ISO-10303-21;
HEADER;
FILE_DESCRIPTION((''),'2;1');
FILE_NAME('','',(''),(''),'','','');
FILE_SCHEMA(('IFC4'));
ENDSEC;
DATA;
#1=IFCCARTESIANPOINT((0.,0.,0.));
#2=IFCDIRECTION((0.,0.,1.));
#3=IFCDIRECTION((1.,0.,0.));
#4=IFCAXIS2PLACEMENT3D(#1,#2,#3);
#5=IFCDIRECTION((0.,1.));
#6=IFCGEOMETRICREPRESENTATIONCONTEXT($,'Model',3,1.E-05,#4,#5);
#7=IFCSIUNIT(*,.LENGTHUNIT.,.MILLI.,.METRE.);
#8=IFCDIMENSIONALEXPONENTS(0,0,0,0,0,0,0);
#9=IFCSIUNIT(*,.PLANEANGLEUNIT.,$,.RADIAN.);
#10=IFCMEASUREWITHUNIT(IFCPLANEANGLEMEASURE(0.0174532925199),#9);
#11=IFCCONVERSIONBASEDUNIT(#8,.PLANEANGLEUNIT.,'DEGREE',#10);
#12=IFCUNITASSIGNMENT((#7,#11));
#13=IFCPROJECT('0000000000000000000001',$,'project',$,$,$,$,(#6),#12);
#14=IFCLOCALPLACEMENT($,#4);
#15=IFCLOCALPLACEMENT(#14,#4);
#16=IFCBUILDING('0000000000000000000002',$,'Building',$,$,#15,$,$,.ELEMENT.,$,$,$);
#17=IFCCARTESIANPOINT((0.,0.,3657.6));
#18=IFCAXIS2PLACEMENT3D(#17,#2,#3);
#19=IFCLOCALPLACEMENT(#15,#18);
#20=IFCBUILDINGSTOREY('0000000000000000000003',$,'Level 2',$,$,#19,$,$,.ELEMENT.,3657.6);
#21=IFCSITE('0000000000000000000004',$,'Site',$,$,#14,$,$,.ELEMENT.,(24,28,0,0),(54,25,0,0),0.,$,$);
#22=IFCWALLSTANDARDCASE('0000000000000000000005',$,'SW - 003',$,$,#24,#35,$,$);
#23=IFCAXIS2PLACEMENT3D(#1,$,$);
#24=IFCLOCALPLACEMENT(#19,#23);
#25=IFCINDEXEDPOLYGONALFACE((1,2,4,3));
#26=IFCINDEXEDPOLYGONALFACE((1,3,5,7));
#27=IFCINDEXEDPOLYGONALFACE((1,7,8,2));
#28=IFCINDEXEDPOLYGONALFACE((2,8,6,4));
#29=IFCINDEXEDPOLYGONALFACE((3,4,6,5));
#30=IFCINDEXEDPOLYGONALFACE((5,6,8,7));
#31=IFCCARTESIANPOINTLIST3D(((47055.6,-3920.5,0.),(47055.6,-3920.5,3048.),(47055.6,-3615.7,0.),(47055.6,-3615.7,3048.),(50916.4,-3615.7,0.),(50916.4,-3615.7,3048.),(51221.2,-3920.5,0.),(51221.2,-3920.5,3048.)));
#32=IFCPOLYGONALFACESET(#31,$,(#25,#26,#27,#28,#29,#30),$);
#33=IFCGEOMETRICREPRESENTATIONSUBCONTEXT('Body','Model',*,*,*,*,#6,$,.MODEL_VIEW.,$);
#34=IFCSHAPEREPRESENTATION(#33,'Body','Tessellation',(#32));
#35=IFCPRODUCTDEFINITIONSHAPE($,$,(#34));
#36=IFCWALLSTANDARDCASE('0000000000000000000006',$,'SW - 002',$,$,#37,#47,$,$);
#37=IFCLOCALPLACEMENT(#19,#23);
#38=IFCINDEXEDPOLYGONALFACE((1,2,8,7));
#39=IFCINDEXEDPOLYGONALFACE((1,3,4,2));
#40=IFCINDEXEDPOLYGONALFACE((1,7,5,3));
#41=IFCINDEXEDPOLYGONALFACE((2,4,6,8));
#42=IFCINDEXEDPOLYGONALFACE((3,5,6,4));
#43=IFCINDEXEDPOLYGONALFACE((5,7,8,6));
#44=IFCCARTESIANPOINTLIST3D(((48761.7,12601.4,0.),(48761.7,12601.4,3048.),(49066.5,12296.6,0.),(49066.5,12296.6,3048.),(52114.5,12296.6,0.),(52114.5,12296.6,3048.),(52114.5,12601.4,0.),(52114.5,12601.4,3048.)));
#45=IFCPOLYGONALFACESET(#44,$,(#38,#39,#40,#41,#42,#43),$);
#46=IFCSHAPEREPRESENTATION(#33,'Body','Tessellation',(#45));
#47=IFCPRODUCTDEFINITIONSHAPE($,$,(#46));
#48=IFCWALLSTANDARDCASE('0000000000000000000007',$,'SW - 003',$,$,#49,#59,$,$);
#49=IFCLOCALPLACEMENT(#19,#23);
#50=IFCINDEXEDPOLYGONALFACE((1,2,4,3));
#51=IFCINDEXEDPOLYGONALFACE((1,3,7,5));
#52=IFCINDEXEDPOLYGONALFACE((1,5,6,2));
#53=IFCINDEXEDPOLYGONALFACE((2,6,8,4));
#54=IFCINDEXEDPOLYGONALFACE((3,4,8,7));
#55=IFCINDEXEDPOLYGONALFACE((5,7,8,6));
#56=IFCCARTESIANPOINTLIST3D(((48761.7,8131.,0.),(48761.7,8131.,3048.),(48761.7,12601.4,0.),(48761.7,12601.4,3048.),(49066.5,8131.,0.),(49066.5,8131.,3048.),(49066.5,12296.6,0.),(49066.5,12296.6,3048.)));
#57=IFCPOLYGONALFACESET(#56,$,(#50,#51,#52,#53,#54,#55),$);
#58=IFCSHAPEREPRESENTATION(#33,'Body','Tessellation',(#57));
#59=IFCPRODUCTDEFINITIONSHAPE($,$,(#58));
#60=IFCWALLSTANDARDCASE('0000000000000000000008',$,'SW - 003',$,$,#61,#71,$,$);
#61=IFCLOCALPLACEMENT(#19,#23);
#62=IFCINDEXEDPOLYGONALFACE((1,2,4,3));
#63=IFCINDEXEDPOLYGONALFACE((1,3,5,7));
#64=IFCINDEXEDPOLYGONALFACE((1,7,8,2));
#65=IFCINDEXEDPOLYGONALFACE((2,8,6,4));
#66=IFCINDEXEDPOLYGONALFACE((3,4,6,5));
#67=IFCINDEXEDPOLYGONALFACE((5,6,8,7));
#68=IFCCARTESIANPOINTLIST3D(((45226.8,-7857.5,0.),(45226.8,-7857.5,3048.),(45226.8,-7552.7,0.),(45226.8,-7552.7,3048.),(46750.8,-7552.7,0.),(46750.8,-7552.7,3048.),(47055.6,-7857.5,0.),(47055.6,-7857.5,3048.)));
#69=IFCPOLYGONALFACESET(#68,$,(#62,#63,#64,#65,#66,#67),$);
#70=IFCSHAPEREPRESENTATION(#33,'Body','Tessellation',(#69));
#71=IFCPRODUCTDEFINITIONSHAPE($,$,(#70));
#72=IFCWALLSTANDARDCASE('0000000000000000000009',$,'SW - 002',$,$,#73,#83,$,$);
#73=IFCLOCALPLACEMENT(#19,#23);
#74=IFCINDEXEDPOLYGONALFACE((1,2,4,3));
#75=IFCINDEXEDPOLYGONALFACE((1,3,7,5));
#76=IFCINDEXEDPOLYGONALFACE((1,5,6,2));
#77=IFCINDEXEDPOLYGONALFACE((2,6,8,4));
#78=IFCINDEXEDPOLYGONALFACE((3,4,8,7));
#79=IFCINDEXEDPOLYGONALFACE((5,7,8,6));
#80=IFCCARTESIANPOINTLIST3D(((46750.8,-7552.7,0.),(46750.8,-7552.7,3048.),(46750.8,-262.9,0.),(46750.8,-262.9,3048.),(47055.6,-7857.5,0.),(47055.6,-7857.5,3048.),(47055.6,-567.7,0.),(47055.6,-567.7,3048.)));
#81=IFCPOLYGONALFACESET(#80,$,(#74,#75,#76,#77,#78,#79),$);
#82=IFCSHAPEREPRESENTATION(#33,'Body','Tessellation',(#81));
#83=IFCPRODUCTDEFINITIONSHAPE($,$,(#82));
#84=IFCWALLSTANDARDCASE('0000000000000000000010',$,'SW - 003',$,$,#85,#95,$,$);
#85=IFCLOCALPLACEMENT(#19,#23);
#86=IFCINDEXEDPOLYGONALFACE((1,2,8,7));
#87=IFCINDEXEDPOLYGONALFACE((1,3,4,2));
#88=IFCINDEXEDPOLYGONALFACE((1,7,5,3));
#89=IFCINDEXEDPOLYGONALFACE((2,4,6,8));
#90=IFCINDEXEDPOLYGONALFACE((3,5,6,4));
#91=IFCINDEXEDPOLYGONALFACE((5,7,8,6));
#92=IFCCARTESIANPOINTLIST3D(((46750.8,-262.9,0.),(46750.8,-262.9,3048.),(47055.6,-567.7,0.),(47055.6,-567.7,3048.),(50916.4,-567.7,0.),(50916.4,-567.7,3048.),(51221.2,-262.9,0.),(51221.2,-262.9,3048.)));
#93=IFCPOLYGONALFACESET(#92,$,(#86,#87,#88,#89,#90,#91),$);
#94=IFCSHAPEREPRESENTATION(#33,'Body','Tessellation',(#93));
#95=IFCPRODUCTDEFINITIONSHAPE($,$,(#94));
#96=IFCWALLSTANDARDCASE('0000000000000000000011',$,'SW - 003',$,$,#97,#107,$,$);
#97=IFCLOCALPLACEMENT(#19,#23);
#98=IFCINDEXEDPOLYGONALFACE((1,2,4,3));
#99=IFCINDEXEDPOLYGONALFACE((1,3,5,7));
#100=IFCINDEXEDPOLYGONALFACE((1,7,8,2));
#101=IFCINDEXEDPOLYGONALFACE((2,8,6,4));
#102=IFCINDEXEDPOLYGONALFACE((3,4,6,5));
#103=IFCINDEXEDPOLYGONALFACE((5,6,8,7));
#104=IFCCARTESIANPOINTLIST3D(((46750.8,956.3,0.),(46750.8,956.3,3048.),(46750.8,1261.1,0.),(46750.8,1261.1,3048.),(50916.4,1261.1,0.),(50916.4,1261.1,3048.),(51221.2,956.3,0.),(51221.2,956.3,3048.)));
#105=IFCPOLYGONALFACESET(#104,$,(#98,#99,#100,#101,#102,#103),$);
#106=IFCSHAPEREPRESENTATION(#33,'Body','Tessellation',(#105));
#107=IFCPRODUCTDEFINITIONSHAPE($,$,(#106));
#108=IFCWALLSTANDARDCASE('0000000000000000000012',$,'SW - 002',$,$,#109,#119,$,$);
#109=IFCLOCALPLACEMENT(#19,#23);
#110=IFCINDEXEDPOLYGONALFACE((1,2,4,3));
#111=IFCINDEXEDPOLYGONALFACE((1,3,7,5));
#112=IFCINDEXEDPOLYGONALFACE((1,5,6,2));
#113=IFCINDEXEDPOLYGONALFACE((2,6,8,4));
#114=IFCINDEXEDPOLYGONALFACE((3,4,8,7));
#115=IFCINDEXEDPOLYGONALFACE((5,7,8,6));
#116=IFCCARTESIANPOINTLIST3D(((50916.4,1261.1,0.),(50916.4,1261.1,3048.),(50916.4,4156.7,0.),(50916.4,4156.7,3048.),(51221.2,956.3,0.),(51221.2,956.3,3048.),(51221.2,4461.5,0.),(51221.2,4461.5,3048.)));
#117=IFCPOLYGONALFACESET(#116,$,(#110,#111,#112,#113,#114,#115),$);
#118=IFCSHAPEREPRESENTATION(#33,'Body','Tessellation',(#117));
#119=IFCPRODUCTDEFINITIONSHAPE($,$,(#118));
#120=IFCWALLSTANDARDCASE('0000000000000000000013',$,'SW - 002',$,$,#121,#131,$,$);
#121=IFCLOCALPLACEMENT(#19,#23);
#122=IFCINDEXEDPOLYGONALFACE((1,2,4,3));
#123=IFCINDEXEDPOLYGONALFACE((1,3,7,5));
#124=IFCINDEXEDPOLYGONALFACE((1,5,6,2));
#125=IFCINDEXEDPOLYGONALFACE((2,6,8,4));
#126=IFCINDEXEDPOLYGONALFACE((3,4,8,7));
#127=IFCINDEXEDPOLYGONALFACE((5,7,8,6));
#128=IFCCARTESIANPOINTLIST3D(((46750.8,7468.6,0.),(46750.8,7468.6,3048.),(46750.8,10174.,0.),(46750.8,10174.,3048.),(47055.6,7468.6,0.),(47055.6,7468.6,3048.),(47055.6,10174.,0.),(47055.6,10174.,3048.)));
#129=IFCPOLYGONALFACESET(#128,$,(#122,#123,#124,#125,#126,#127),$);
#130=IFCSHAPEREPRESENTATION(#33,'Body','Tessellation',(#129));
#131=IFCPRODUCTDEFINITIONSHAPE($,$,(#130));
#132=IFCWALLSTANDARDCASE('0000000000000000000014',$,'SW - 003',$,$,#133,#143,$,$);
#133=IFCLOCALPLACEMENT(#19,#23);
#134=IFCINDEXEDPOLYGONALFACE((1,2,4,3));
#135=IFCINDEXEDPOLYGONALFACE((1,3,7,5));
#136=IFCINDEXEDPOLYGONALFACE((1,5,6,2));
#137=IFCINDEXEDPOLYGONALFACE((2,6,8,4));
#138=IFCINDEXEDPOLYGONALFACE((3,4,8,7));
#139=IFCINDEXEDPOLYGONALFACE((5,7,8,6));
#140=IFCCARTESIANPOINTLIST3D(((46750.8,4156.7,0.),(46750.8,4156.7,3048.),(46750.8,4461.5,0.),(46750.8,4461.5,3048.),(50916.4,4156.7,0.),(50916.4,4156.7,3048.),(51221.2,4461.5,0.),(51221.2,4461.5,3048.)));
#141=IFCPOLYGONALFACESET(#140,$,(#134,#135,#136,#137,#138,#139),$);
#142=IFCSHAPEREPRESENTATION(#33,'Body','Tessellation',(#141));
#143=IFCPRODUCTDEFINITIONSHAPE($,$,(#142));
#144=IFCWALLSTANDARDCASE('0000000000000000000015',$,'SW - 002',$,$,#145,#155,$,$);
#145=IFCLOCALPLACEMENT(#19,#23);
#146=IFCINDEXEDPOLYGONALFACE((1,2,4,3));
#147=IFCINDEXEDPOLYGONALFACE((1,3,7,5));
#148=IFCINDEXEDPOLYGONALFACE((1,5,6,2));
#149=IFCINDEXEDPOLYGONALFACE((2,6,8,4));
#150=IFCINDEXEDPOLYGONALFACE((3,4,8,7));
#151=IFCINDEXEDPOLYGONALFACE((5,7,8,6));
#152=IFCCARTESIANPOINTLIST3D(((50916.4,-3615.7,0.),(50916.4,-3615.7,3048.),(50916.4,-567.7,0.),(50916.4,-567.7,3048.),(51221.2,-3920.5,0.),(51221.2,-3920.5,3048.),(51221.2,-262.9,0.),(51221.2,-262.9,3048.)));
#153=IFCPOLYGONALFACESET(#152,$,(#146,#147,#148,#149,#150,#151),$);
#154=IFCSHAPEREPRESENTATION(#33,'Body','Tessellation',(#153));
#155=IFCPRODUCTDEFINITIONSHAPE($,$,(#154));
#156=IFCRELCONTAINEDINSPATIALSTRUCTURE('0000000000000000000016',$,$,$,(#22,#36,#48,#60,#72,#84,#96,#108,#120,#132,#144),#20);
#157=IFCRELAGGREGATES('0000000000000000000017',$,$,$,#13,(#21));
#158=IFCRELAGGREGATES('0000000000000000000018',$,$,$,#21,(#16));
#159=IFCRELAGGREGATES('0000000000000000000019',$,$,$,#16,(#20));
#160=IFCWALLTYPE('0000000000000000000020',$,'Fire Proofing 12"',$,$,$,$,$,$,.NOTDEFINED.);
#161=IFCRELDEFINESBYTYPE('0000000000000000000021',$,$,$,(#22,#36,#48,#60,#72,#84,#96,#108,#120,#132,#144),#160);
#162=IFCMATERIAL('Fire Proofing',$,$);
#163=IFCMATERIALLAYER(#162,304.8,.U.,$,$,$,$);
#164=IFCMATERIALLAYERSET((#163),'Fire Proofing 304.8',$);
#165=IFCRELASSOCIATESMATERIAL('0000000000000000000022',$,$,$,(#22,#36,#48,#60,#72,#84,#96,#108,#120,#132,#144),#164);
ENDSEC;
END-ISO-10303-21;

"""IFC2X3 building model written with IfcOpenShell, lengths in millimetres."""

from ifc_helpers import new_model, entity, si_unit, converted_unit, direction, frame, origin_with_axes, place, context, subcontext, project, spatial, polyline, outline, extrude, material, layer, layer_set, layer_usage, type_object, element, save


model = new_model("IFC2X3")

# Units and contexts
model_context = context("Model", 3, precision=1e-05, world=origin_with_axes(), true_north=direction((0.0, 1.0)))
body_context = subcontext(model_context, "Body", "Model", "MODEL_VIEW")
ifc_project = project(units=[si_unit("LENGTHUNIT", "METRE", prefix="MILLI"), converted_unit("PLANEANGLEUNIT", "DEGREE", entity("IfcPlaneAngleMeasure", 0.0174532925199), si_unit("PLANEANGLEUNIT", "RADIAN"), dimensions=[0, 0, 0, 0, 0, 0, 0])], contexts=[model_context])

# Site, building, storey
site_placement = place(None, origin_with_axes())
site = spatial("IfcSite", under=ifc_project, at=site_placement, Name="Site", CompositionType="ELEMENT", RefLatitude=(24, 28, 0, 0), RefLongitude=(54, 25, 0, 0), RefElevation=0.0)
building_placement = place(site_placement, origin_with_axes())
building = spatial("IfcBuilding", under=site, at=building_placement, Name="Building", CompositionType="ELEMENT")
storey_placement = place(building_placement, frame((0.0, 0.0, 3657.6), z_axis=(0.0, 0.0, 1.0), x_axis=(1.0, 0.0, 0.0)))
storey = spatial("IfcBuildingStorey", under=building, at=storey_placement, Name="Level 2", CompositionType="ELEMENT", Elevation=3657.6)

# Walls
ifc_material_1 = material(Name="Fire Proofing")
ifc_layer = layer(ifc_material_1, 304.8, ventilated="UNKNOWN")
ifc_layer_set = layer_set([ifc_layer], Name="Fire Proofing 304.8")
ifc_layer_usage_1 = layer_usage(ifc_layer_set, "AXIS2", "NEGATIVE", 152.4)
wall_type = type_object("IfcWallType", Name="Fire Proofing 12\"", PredefinedType="NOTDEFINED")
wall_1_placement = place(storey_placement, frame((51068.8, -3768.1, 0.0), z_axis=(0.0, 0.0, 1.0), x_axis=(-1.0, 0.0, 0.0)))
element("IfcWallStandardCase", 1, at=wall_1_placement, inside=storey, type_object=wall_type, material=ifc_layer_usage_1, Name="SW - 003", context=body_context, shape_type="SweptSolid", body=[
    extrude(outline(polyline([(152.4, -152.4), (4013.2, -152.4), (4013.2, 152.4), (-152.4, 152.4), (152.4, -152.4)])), origin_with_axes(), (0.0, 0.0, 1.0), 3048.0),
])
ifc_layer_usage_2 = layer_usage(ifc_layer_set, "AXIS2", "NEGATIVE", 152.4)
wall_2_placement = place(storey_placement, frame((52114.5, 12449.0, 0.0), z_axis=(0.0, 0.0, 1.0), x_axis=(-1.0, 0.0, 0.0)))
element("IfcWallStandardCase", 2, at=wall_2_placement, inside=storey, type_object=wall_type, material=ifc_layer_usage_2, Name="SW - 002", context=body_context, shape_type="SweptSolid", body=[
    extrude(outline(polyline([(0.0, -152.4), (3352.8, -152.4), (3048.0, 152.4), (0.0, 152.4), (0.0, -152.4)])), origin_with_axes(), (0.0, 0.0, 1.0), 3048.0),
])
ifc_layer_usage_3 = layer_usage(ifc_layer_set, "AXIS2", "NEGATIVE", 152.4)
wall_3_placement = place(storey_placement, frame((48914.1, 12449.0, 0.0), z_axis=(0.0, 0.0, 1.0), x_axis=(0.0, -1.0, 0.0)))
element("IfcWallStandardCase", 3, at=wall_3_placement, inside=storey, type_object=wall_type, material=ifc_layer_usage_3, Name="SW - 003", context=body_context, shape_type="SweptSolid", body=[
    extrude(outline(polyline([(-152.4, -152.4), (4318.0, -152.4), (4318.0, 152.4), (152.4, 152.4), (-152.4, -152.4)])), origin_with_axes(), (0.0, 0.0, 1.0), 3048.0),
])
ifc_layer_usage_4 = layer_usage(ifc_layer_set, "AXIS2", "NEGATIVE", 152.4)
wall_4_placement = place(storey_placement, frame((46903.2, -7705.1, 0.0), z_axis=(0.0, 0.0, 1.0), x_axis=(-1.0, 0.0, 0.0)))
element("IfcWallStandardCase", 4, at=wall_4_placement, inside=storey, type_object=wall_type, material=ifc_layer_usage_4, Name="SW - 003", context=body_context, shape_type="SweptSolid", body=[
    extrude(outline(polyline([(152.4, -152.4), (1676.4, -152.4), (1676.4, 152.4), (-152.4, 152.4), (152.4, -152.4)])), origin_with_axes(), (0.0, 0.0, 1.0), 3048.0),
])
ifc_layer_usage_5 = layer_usage(ifc_layer_set, "AXIS2", "NEGATIVE", 152.4)
wall_5_placement = place(storey_placement, frame((46903.2, -7705.1, 0.0), z_axis=(0.0, 0.0, 1.0), x_axis=(0.0, 1.0, 0.0)))
element("IfcWallStandardCase", 5, at=wall_5_placement, inside=storey, type_object=wall_type, material=ifc_layer_usage_5, Name="SW - 002", context=body_context, shape_type="SweptSolid", body=[
    extrude(outline(polyline([(-152.4, -152.4), (7137.4, -152.4), (7442.2, 152.4), (152.4, 152.4), (-152.4, -152.4)])), origin_with_axes(), (0.0, 0.0, 1.0), 3048.0),
])
ifc_layer_usage_6 = layer_usage(ifc_layer_set, "AXIS2", "NEGATIVE", 152.4)
wall_6_placement = place(storey_placement, frame((51068.8, -415.3, 0.0), z_axis=(0.0, 0.0, 1.0), x_axis=(-1.0, 0.0, 0.0)))
element("IfcWallStandardCase", 6, at=wall_6_placement, inside=storey, type_object=wall_type, material=ifc_layer_usage_6, Name="SW - 003", context=body_context, shape_type="SweptSolid", body=[
    extrude(outline(polyline([(-152.4, -152.4), (4318.0, -152.4), (4013.2, 152.4), (152.4, 152.4), (-152.4, -152.4)])), origin_with_axes(), (0.0, 0.0, 1.0), 3048.0),
])
ifc_layer_usage_7 = layer_usage(ifc_layer_set, "AXIS2", "NEGATIVE", 152.4)
wall_7_placement = place(storey_placement, frame((51068.8, 1108.7, 0.0), z_axis=(0.0, 0.0, 1.0), x_axis=(-1.0, 0.0, 0.0)))
element("IfcWallStandardCase", 7, at=wall_7_placement, inside=storey, type_object=wall_type, material=ifc_layer_usage_7, Name="SW - 003", context=body_context, shape_type="SweptSolid", body=[
    extrude(outline(polyline([(152.4, -152.4), (4318.0, -152.4), (4318.0, 152.4), (-152.4, 152.4), (152.4, -152.4)])), origin_with_axes(), (0.0, 0.0, 1.0), 3048.0),
])
ifc_layer_usage_8 = layer_usage(ifc_layer_set, "AXIS2", "NEGATIVE", 152.4)
wall_8_placement = place(storey_placement, frame((51068.8, 1108.7, 0.0), z_axis=(0.0, 0.0, 1.0), x_axis=(0.0, 1.0, 0.0)))
element("IfcWallStandardCase", 8, at=wall_8_placement, inside=storey, type_object=wall_type, material=ifc_layer_usage_8, Name="SW - 002", context=body_context, shape_type="SweptSolid", body=[
    extrude(outline(polyline([(-152.4, -152.4), (3352.8, -152.4), (3048.0, 152.4), (152.4, 152.4), (-152.4, -152.4)])), origin_with_axes(), (0.0, 0.0, 1.0), 3048.0),
])
ifc_layer_usage_9 = layer_usage(ifc_layer_set, "AXIS2", "NEGATIVE", 152.4)
wall_9_placement = place(storey_placement, frame((46903.2, 7468.6, 0.0), z_axis=(0.0, 0.0, 1.0), x_axis=(0.0, 1.0, 0.0)))
element("IfcWallStandardCase", 9, at=wall_9_placement, inside=storey, type_object=wall_type, material=ifc_layer_usage_9, Name="SW - 002", context=body_context, shape_type="SweptSolid", body=[
    extrude(outline(polyline([(0.0, -152.4), (2705.5, -152.4), (2705.5, 152.4), (0.0, 152.4), (0.0, -152.4)])), origin_with_axes(), (0.0, 0.0, 1.0), 3048.0),
])
ifc_layer_usage_10 = layer_usage(ifc_layer_set, "AXIS2", "NEGATIVE", 152.4)
wall_10_placement = place(storey_placement, frame((51068.8, 4309.1, 0.0), z_axis=(0.0, 0.0, 1.0), x_axis=(-1.0, 0.0, 0.0)))
element("IfcWallStandardCase", 10, at=wall_10_placement, inside=storey, type_object=wall_type, material=ifc_layer_usage_10, Name="SW - 003", context=body_context, shape_type="SweptSolid", body=[
    extrude(outline(polyline([(-152.4, -152.4), (4318.0, -152.4), (4318.0, 152.4), (152.4, 152.4), (-152.4, -152.4)])), origin_with_axes(), (0.0, 0.0, 1.0), 3048.0),
])
ifc_layer_usage_11 = layer_usage(ifc_layer_set, "AXIS2", "NEGATIVE", 152.4)
wall_11_placement = place(storey_placement, frame((51068.8, -3768.1, 0.0), z_axis=(0.0, 0.0, 1.0), x_axis=(0.0, 1.0, 0.0)))
element("IfcWallStandardCase", 11, at=wall_11_placement, inside=storey, type_object=wall_type, material=ifc_layer_usage_11, Name="SW - 002", context=body_context, shape_type="SweptSolid", body=[
    extrude(outline(polyline([(-152.4, -152.4), (3505.2, -152.4), (3200.4, 152.4), (152.4, 152.4), (-152.4, -152.4)])), origin_with_axes(), (0.0, 0.0, 1.0), 3048.0),
])

save(model, "model.ifc")
